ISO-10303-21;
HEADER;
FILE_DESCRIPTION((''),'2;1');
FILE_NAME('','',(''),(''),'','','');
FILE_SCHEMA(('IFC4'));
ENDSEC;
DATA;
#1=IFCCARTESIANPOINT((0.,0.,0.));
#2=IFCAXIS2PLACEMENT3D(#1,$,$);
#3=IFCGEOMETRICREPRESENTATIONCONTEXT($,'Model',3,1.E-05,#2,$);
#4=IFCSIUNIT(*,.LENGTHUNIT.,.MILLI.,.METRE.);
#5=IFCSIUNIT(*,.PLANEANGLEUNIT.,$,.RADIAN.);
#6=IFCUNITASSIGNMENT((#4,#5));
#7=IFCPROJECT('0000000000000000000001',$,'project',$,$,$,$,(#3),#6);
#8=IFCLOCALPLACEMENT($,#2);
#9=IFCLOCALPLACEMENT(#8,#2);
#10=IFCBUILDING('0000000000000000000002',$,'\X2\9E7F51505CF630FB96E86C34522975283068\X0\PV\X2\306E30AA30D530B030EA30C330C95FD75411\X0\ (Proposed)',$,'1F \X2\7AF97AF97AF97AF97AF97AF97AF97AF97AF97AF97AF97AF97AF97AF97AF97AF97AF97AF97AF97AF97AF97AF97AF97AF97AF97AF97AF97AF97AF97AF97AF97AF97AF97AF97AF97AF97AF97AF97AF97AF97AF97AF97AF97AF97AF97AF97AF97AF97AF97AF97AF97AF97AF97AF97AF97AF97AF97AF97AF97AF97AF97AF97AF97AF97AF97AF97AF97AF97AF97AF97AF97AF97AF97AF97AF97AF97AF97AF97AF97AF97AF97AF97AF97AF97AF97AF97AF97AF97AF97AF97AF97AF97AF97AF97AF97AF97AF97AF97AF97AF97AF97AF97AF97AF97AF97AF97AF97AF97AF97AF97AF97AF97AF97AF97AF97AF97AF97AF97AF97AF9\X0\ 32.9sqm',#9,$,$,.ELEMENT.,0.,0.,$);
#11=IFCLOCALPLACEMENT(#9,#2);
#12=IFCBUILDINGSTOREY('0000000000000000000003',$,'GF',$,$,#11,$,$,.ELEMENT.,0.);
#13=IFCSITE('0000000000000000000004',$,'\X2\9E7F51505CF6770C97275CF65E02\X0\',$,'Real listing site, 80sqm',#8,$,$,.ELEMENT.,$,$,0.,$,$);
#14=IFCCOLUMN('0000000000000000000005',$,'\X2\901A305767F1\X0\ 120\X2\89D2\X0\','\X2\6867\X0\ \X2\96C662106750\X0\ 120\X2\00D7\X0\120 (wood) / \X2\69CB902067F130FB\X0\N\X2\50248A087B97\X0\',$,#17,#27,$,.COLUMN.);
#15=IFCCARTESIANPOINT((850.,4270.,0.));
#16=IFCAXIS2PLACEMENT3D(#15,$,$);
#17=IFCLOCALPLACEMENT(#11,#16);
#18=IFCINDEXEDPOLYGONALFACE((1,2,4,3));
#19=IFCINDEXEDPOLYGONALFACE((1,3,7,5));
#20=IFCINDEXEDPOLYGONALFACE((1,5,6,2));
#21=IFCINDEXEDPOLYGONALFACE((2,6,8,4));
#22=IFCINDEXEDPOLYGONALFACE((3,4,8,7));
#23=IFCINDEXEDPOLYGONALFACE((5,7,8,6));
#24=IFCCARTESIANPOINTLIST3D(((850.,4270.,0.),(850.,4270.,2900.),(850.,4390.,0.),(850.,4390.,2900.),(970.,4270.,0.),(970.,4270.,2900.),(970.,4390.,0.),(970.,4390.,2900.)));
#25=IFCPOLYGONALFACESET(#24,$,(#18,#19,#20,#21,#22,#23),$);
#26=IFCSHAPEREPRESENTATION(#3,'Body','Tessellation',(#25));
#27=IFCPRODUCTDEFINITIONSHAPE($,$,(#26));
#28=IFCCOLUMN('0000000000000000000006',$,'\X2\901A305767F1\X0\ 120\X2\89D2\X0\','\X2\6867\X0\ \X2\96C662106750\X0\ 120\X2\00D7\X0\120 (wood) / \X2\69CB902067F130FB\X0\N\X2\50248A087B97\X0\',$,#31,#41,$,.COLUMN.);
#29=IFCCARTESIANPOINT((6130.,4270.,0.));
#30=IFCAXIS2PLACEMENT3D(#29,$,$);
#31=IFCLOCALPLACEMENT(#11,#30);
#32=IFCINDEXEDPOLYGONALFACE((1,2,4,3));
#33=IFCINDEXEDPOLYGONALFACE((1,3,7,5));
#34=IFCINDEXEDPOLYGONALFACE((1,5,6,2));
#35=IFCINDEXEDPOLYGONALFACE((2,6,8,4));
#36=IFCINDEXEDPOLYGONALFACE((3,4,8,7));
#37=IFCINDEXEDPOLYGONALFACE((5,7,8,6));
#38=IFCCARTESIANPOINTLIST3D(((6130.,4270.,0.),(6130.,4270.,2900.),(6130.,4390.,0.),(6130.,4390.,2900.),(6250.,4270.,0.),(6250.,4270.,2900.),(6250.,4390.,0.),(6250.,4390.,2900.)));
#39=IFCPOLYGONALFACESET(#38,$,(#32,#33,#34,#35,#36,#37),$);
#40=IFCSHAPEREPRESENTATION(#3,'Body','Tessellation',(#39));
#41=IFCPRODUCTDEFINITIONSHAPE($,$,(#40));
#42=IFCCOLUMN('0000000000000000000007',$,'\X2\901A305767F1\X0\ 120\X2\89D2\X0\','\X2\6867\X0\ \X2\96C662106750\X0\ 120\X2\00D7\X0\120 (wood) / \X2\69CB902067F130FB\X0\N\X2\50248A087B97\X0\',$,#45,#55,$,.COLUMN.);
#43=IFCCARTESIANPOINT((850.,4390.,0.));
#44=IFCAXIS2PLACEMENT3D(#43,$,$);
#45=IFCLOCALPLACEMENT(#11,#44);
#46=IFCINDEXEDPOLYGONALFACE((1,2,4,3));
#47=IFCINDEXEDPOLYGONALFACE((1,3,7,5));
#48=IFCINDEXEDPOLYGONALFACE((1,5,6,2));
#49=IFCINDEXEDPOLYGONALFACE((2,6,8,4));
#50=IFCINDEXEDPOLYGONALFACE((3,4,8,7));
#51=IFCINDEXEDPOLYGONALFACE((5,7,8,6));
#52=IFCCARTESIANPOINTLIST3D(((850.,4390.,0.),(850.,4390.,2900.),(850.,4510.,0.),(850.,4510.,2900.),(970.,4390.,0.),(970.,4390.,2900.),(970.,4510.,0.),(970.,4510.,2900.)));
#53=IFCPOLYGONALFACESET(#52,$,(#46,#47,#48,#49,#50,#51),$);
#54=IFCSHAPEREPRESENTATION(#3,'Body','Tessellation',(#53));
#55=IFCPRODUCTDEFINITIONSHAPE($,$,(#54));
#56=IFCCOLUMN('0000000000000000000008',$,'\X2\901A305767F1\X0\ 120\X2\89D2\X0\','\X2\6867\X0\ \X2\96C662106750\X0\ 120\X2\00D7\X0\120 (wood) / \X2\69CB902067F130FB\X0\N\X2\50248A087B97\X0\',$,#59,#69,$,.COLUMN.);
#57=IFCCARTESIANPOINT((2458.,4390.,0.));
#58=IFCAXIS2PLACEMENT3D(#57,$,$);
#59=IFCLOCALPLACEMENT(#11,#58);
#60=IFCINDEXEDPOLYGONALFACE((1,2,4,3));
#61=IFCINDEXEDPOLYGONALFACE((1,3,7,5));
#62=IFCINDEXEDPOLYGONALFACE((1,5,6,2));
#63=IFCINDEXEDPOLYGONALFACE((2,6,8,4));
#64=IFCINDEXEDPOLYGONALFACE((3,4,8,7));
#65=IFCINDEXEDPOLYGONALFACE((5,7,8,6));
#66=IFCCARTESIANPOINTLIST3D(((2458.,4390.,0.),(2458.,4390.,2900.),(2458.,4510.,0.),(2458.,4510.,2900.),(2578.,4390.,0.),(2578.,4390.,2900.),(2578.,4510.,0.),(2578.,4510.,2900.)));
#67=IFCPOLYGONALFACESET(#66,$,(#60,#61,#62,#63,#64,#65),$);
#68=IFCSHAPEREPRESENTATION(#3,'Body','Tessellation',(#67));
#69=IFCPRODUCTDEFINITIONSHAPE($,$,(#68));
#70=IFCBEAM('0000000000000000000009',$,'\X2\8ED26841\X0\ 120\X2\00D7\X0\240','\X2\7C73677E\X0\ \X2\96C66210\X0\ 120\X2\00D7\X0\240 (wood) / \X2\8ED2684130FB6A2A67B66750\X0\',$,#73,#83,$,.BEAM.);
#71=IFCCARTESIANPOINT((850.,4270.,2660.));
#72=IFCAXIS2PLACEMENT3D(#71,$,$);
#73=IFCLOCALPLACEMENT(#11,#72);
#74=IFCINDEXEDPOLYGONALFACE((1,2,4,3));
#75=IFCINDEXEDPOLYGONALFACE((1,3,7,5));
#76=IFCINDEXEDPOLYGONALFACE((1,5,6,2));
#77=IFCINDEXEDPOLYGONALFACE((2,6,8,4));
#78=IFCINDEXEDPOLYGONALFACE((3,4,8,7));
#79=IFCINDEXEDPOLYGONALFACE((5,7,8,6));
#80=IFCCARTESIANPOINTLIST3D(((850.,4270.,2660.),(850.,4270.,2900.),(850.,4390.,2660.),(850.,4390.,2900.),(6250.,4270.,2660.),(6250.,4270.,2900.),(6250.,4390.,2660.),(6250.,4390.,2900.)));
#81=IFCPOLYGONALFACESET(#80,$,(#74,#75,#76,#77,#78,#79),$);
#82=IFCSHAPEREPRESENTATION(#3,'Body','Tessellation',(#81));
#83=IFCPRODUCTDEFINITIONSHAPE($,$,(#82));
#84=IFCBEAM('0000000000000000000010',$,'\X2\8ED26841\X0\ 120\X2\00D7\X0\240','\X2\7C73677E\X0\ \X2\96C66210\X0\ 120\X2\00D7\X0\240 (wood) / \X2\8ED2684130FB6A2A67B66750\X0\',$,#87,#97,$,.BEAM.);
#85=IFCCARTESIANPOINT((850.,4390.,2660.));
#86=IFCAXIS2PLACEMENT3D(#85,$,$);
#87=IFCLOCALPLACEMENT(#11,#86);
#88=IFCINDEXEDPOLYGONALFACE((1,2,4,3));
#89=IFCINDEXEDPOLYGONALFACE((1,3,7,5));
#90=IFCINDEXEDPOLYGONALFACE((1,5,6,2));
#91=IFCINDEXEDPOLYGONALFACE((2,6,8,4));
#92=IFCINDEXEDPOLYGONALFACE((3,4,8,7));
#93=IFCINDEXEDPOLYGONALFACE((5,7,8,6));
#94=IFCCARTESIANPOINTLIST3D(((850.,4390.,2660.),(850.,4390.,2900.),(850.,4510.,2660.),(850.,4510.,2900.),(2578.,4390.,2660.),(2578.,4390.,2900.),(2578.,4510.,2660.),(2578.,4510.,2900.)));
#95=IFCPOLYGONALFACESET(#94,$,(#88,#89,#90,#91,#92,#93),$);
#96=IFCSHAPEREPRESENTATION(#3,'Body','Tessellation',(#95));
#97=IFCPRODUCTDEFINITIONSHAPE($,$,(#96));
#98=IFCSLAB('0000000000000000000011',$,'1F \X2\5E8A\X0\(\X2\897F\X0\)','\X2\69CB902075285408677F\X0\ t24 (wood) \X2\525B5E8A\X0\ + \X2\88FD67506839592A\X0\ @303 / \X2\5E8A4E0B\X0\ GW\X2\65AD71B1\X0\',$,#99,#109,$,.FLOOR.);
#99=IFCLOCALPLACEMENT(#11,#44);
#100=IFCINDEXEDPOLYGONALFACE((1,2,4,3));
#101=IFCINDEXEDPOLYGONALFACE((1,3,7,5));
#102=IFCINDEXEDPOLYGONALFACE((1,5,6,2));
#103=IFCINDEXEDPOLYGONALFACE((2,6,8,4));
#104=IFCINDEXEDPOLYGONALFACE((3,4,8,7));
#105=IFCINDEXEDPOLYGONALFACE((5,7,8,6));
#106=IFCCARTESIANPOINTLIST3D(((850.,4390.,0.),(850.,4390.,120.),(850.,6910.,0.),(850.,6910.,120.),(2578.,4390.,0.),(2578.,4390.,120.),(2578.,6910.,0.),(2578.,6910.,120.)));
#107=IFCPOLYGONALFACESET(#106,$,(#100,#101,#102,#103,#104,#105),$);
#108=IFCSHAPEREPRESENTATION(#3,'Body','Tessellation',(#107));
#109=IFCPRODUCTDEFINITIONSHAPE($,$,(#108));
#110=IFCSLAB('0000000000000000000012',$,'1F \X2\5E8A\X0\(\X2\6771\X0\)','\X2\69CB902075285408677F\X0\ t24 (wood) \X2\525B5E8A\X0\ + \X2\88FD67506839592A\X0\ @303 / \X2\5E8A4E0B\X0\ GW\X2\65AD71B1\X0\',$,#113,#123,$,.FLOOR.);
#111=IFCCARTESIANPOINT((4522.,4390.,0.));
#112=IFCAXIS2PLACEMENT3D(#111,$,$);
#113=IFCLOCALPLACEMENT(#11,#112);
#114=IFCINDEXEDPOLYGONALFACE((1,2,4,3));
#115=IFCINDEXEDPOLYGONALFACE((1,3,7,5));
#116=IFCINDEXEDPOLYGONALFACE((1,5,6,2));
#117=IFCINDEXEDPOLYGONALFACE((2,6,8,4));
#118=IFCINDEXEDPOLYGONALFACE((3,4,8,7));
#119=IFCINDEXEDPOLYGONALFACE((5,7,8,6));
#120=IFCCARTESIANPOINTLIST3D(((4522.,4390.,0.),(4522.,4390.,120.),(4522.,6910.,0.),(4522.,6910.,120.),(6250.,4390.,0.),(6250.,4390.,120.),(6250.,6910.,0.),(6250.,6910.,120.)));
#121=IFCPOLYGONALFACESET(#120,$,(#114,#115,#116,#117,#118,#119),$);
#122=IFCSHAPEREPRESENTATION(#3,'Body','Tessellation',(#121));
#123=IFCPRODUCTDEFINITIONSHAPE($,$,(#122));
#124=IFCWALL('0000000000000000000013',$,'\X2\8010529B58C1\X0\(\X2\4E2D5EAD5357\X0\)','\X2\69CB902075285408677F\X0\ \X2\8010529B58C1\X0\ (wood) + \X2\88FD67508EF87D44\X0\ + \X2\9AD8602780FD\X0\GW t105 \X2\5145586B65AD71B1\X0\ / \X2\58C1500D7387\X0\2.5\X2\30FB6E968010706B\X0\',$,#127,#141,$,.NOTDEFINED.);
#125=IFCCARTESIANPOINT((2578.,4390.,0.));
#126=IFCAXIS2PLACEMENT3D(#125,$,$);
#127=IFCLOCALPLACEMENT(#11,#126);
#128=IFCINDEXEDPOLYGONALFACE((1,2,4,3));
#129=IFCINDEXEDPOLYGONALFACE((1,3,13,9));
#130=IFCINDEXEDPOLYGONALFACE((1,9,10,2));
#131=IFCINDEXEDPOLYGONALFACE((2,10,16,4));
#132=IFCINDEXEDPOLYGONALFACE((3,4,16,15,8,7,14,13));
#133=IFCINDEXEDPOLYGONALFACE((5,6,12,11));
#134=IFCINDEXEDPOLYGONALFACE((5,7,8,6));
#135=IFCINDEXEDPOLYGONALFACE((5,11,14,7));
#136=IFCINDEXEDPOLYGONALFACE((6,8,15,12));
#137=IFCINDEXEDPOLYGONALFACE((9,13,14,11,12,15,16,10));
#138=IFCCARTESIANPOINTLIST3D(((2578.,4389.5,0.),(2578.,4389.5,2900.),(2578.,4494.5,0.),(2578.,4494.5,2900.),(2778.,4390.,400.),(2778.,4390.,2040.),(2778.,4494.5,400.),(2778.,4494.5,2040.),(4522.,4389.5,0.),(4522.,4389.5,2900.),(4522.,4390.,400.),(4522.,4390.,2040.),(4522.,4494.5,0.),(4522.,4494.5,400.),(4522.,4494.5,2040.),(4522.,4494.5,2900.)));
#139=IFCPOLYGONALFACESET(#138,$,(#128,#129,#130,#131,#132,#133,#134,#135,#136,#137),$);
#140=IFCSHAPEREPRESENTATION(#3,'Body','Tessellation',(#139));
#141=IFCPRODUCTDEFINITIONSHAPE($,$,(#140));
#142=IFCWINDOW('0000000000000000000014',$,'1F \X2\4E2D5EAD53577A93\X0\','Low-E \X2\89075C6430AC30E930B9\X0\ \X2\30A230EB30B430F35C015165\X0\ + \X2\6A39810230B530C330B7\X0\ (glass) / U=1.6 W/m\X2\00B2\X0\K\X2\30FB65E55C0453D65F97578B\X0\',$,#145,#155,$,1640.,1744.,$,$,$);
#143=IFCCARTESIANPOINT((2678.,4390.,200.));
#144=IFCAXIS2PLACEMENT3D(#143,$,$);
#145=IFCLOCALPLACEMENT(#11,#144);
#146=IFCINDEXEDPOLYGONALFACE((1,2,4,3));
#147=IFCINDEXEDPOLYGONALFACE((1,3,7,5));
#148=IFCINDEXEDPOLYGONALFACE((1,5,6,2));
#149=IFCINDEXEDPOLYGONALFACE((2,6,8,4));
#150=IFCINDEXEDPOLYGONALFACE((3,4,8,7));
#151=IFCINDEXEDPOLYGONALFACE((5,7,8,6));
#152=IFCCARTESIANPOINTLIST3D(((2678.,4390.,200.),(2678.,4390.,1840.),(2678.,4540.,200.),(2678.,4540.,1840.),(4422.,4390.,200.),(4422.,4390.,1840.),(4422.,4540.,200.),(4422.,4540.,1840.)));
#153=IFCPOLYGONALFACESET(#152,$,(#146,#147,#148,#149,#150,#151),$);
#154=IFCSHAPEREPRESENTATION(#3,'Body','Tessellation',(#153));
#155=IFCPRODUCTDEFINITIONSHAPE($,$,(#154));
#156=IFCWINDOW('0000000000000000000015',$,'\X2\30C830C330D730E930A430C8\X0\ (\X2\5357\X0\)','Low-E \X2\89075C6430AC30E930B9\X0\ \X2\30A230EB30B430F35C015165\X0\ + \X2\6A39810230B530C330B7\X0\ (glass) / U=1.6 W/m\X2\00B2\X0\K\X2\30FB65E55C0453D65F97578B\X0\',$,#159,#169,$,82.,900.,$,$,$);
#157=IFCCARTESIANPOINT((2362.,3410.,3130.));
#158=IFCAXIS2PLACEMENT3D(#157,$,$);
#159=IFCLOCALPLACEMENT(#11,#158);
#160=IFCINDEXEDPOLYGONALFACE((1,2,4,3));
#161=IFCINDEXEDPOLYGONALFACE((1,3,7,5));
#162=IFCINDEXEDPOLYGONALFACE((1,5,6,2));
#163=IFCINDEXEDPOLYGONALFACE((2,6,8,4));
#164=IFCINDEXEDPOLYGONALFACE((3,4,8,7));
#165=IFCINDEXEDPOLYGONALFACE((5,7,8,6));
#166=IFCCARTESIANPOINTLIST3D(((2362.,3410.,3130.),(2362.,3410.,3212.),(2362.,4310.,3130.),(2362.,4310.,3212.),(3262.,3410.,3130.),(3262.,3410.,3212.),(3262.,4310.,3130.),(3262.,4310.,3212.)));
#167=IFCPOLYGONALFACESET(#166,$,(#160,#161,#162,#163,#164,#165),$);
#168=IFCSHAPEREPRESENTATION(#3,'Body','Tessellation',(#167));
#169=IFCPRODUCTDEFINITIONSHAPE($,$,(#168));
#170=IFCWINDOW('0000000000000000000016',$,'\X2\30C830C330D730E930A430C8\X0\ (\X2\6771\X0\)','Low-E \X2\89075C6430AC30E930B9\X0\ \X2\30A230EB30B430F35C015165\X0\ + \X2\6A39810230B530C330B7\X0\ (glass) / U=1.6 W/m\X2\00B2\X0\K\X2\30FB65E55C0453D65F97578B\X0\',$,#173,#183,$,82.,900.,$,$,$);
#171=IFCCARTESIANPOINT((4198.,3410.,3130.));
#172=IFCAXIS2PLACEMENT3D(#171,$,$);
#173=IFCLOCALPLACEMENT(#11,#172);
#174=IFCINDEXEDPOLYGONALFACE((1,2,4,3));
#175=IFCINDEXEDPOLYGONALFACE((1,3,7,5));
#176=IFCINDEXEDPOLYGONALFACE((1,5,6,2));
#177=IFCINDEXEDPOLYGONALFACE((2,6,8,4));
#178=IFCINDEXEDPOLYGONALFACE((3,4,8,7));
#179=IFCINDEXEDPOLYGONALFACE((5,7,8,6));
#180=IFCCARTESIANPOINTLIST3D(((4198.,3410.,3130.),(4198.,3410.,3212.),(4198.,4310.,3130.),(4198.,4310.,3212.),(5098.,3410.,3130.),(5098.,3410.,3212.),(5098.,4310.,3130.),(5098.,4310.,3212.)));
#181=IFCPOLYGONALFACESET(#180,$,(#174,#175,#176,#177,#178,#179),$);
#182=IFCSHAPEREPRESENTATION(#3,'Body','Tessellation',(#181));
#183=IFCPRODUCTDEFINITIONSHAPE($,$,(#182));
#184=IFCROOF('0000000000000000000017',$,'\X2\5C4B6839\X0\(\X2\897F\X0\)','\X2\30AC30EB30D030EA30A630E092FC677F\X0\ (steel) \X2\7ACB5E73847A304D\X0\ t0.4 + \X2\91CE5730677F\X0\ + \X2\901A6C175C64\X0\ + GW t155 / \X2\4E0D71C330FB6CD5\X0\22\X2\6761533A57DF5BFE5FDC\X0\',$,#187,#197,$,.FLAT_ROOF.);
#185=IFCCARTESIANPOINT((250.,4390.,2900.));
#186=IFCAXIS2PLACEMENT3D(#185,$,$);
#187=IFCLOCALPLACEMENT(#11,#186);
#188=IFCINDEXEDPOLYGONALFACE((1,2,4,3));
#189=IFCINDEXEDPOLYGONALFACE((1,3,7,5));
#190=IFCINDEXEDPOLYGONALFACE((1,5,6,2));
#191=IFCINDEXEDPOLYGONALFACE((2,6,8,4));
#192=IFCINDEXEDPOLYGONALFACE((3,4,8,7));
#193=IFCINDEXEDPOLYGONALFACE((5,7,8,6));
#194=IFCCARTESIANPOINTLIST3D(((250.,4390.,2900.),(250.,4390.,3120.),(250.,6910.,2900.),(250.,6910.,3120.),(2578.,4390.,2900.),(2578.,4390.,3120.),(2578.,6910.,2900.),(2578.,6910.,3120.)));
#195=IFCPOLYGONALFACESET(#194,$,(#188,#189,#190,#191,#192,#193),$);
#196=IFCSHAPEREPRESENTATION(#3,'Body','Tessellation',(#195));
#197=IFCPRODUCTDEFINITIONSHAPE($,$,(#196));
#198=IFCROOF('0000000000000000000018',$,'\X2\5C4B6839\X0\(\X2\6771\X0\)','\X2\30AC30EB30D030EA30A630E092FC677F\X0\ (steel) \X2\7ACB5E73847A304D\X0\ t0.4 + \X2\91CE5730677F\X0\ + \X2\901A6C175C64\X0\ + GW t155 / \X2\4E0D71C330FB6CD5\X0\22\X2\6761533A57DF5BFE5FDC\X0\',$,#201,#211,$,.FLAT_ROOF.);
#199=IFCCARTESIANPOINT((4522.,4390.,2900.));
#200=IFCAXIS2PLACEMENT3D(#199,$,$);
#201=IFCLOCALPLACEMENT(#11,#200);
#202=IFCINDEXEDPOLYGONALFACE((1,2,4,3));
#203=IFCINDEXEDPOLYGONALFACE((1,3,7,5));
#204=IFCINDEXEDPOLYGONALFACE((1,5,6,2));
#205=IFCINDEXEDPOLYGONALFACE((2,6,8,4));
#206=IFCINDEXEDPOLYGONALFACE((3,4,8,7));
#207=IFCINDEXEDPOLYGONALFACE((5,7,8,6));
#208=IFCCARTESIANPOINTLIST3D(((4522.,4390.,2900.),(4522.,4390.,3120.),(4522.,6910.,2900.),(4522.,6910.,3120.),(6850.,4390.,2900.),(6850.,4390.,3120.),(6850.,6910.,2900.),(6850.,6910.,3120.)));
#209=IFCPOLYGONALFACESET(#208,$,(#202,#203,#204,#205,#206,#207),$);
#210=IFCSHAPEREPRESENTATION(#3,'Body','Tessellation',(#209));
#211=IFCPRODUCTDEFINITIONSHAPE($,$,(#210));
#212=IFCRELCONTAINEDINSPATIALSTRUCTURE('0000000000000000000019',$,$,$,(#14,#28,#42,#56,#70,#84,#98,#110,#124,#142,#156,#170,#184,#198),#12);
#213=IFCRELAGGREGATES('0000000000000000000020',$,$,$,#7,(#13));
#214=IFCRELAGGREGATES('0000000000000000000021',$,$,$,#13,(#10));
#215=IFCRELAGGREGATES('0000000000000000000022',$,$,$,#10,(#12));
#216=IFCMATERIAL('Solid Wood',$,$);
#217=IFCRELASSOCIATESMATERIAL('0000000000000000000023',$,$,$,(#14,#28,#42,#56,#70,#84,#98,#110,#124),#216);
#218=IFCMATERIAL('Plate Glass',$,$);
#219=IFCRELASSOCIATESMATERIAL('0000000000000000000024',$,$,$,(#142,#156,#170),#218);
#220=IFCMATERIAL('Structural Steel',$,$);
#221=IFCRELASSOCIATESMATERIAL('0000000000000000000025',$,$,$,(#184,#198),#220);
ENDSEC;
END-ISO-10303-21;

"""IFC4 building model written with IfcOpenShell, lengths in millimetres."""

from ifc_helpers import new_model, si_unit, frame, frame_2d, origin, place, context, project, spatial, rectangle, extrude, material, element, fill, save


model = new_model("IFC4")

# Units and contexts
model_context = context("Model", 3, precision=1e-05, world=origin())
ifc_project = project(units=[si_unit("LENGTHUNIT", "METRE", prefix="MILLI"), si_unit("PLANEANGLEUNIT", "RADIAN")], contexts=[model_context])

# Site, building, storey
site_placement = place(None, origin())
site = spatial("IfcSite", under=ifc_project, at=site_placement, Name="鹿児島県霧島市", ObjectType="Real listing site, 80sqm", CompositionType="ELEMENT", RefElevation=0.0)
building_placement = place(site_placement, origin())
building = spatial("IfcBuilding", under=site, at=building_placement, Name="鹿児島・雨水利用とPVのオフグリッド志向 (Proposed)", ObjectType="1F 竹竹竹竹竹竹竹竹竹竹竹竹竹竹竹竹竹竹竹竹竹竹竹竹竹竹竹竹竹竹竹竹竹竹竹竹竹竹竹竹竹竹竹竹竹竹竹竹竹竹竹竹竹竹竹竹竹竹竹竹竹竹竹竹竹竹竹竹竹竹竹竹竹竹竹竹竹竹竹竹竹竹竹竹竹竹竹竹竹竹竹竹竹竹竹竹竹竹竹竹竹竹竹竹竹竹竹竹竹竹竹竹竹竹竹竹竹竹竹竹 32.9sqm", CompositionType="ELEMENT", ElevationOfRefHeight=0.0, ElevationOfTerrain=0.0)
storey_placement = place(building_placement, origin())
storey = spatial("IfcBuildingStorey", under=building, at=storey_placement, Name="GF", CompositionType="ELEMENT", Elevation=0.0)

# Columns
ifc_material_1 = material(Name="Solid Wood")
column_1_placement = place(storey_placement, frame((850.0, 4270.0, 0.0)))
element("IfcColumn", 1, at=column_1_placement, inside=storey, material=ifc_material_1, Name="通し柱 120角", Description="桧 集成材 120×120 (wood) / 構造柱・N値計算", PredefinedType="COLUMN", context=model_context, shape_type="SweptSolid", body=[
    extrude(rectangle(XDim=120.0, YDim=120.0, at=frame_2d((60.0, 60.0))), frame((850.0, 4270.0, 0.0)), (0.0, 0.0, 1.0), 2900.0),
])
column_2_placement = place(storey_placement, frame((6130.0, 4270.0, 0.0)))
element("IfcColumn", 2, at=column_2_placement, inside=storey, material=ifc_material_1, Name="通し柱 120角", Description="桧 集成材 120×120 (wood) / 構造柱・N値計算", PredefinedType="COLUMN", context=model_context, shape_type="SweptSolid", body=[
    extrude(rectangle(XDim=120.0, YDim=120.0, at=frame_2d((60.0, 60.0))), frame((6130.0, 4270.0, 0.0)), (0.0, 0.0, 1.0), 2900.0),
])
column_3_placement = place(storey_placement, frame((850.0, 4390.0, 0.0)))
element("IfcColumn", 3, at=column_3_placement, inside=storey, material=ifc_material_1, Name="通し柱 120角", Description="桧 集成材 120×120 (wood) / 構造柱・N値計算", PredefinedType="COLUMN", context=model_context, shape_type="SweptSolid", body=[
    extrude(rectangle(XDim=120.0, YDim=120.0, at=frame_2d((60.0, 60.0))), frame((850.0, 4390.0, 0.0)), (0.0, 0.0, 1.0), 2900.0),
])
column_4_placement = place(storey_placement, frame((2458.0, 4390.0, 0.0)))
element("IfcColumn", 4, at=column_4_placement, inside=storey, material=ifc_material_1, Name="通し柱 120角", Description="桧 集成材 120×120 (wood) / 構造柱・N値計算", PredefinedType="COLUMN", context=model_context, shape_type="SweptSolid", body=[
    extrude(rectangle(XDim=120.0, YDim=120.0, at=frame_2d((60.0, 60.0))), frame((2458.0, 4390.0, 0.0)), (0.0, 0.0, 1.0), 2900.0),
])

# Beams
beam_1_placement = place(storey_placement, frame((850.0, 4270.0, 2660.0)))
element("IfcBeam", 5, at=beam_1_placement, inside=storey, material=ifc_material_1, Name="軒桁 120×240", Description="米松 集成 120×240 (wood) / 軒桁・横架材", PredefinedType="BEAM", context=model_context, shape_type="SweptSolid", body=[
    extrude(rectangle(XDim=5400.0, YDim=120.0, at=frame_2d((2700.0, 60.0))), frame((850.0, 4270.0, 2660.0)), (0.0, 0.0, 1.0), 240.0),
])
beam_2_placement = place(storey_placement, frame((850.0, 4390.0, 2660.0)))
element("IfcBeam", 6, at=beam_2_placement, inside=storey, material=ifc_material_1, Name="軒桁 120×240", Description="米松 集成 120×240 (wood) / 軒桁・横架材", PredefinedType="BEAM", context=model_context, shape_type="SweptSolid", body=[
    extrude(rectangle(XDim=1728.0, YDim=120.0, at=frame_2d((864.0, 60.0))), frame((850.0, 4390.0, 2660.0)), (0.0, 0.0, 1.0), 240.0),
])

# Slabs
slab_1_placement = place(storey_placement, frame((850.0, 4390.0, 0.0)))
element("IfcSlab", 7, at=slab_1_placement, inside=storey, material=ifc_material_1, Name="1F 床(西)", Description="構造用合板 t24 (wood) 剛床 + 製材根太 @303 / 床下 GW断熱", PredefinedType="FLOOR", context=model_context, shape_type="SweptSolid", body=[
    extrude(rectangle(XDim=1728.0, YDim=2520.0, at=frame_2d((864.0, 1260.0))), frame((850.0, 4390.0, 0.0)), (0.0, 0.0, 1.0), 120.0),
])
slab_2_placement = place(storey_placement, frame((4522.0, 4390.0, 0.0)))
element("IfcSlab", 8, at=slab_2_placement, inside=storey, material=ifc_material_1, Name="1F 床(東)", Description="構造用合板 t24 (wood) 剛床 + 製材根太 @303 / 床下 GW断熱", PredefinedType="FLOOR", context=model_context, shape_type="SweptSolid", body=[
    extrude(rectangle(XDim=1728.0, YDim=2520.0, at=frame_2d((864.0, 1260.0))), frame((4522.0, 4390.0, 0.0)), (0.0, 0.0, 1.0), 120.0),
])

# Wall, opening, window
wall_1_placement = place(storey_placement, frame((2578.0, 4390.0, 0.0)))
wall_1 = element("IfcWall", 9, at=wall_1_placement, inside=storey, material=ifc_material_1, Name="耐力壁(中庭南)", Description="構造用合板 耐力壁 (wood) + 製材軸組 + 高性能GW t105 充填断熱 / 壁倍率2.5・準耐火", PredefinedType="NOTDEFINED", context=model_context, shape_type="SweptSolid", body=[
    extrude(rectangle(XDim=1944.0, YDim=105.0, at=frame_2d((972.0, 52.0))), frame((2578.0, 4390.0, 0.0)), (0.0, 0.0, 1.0), 2900.0),
])
opening_placement = place(storey_placement, frame((2678.0, 4390.0, 200.0)))
opening = element("IfcOpeningElement", 10, at=opening_placement, cuts=wall_1, PredefinedType="NOTDEFINED", context=model_context, shape_type="SweptSolid", body=[
    extrude(rectangle(XDim=1744.0, YDim=150.0, at=frame_2d((872.0, 75.0))), frame((2678.0, 4390.0, 200.0)), (0.0, 0.0, 1.0), 1640.0),
])
ifc_material_2 = material(Name="Plate Glass")
window_1_placement = place(storey_placement, frame((2678.0, 4390.0, 200.0)))
window_1 = element("IfcWindow", 11, at=window_1_placement, inside=storey, material=ifc_material_2, Name="1F 中庭南窓", Description="Low-E 複層ガラス アルゴン封入 + 樹脂サッシ (glass) / U=1.6 W/m²K・日射取得型", OverallHeight=1640.0, OverallWidth=1744.0, context=model_context, shape_type="SweptSolid", body=[
    extrude(rectangle(XDim=1744.0, YDim=150.0, at=frame_2d((872.0, 75.0))), frame((2678.0, 4390.0, 200.0)), (0.0, 0.0, 1.0), 1640.0),
])
fill(opening, window_1)

# Windows
window_2_placement = place(storey_placement, frame((2362.0, 3410.0, 3130.0)))
element("IfcWindow", 12, at=window_2_placement, inside=storey, material=ifc_material_2, Name="トップライト (南)", Description="Low-E 複層ガラス アルゴン封入 + 樹脂サッシ (glass) / U=1.6 W/m²K・日射取得型", OverallHeight=82.0, OverallWidth=900.0, context=model_context, shape_type="SweptSolid", body=[
    extrude(rectangle(XDim=900.0, YDim=900.0, at=frame_2d((450.0, 450.0))), frame((2362.0, 3410.0, 3130.0)), (0.0, 0.0, 1.0), 82.0),
])
window_3_placement = place(storey_placement, frame((4198.0, 3410.0, 3130.0)))
element("IfcWindow", 13, at=window_3_placement, inside=storey, material=ifc_material_2, Name="トップライト (東)", Description="Low-E 複層ガラス アルゴン封入 + 樹脂サッシ (glass) / U=1.6 W/m²K・日射取得型", OverallHeight=82.0, OverallWidth=900.0, context=model_context, shape_type="SweptSolid", body=[
    extrude(rectangle(XDim=900.0, YDim=900.0, at=frame_2d((450.0, 450.0))), frame((4198.0, 3410.0, 3130.0)), (0.0, 0.0, 1.0), 82.0),
])

# Roofs
ifc_material_3 = material(Name="Structural Steel")
roof_1_placement = place(storey_placement, frame((250.0, 4390.0, 2900.0)))
element("IfcRoof", 14, at=roof_1_placement, inside=storey, material=ifc_material_3, Name="屋根(西)", Description="ガルバリウム鋼板 (steel) 立平葺き t0.4 + 野地板 + 通気層 + GW t155 / 不燃・法22条区域対応", PredefinedType="FLAT_ROOF", context=model_context, shape_type="SweptSolid", body=[
    extrude(rectangle(XDim=2328.0, YDim=2520.0, at=frame_2d((1164.0, 1260.0))), frame((250.0, 4390.0, 2900.0)), (0.0, 0.0, 1.0), 220.0),
])
roof_2_placement = place(storey_placement, frame((4522.0, 4390.0, 2900.0)))
element("IfcRoof", 15, at=roof_2_placement, inside=storey, material=ifc_material_3, Name="屋根(東)", Description="ガルバリウム鋼板 (steel) 立平葺き t0.4 + 野地板 + 通気層 + GW t155 / 不燃・法22条区域対応", PredefinedType="FLAT_ROOF", context=model_context, shape_type="SweptSolid", body=[
    extrude(rectangle(XDim=2328.0, YDim=2520.0, at=frame_2d((1164.0, 1260.0))), frame((4522.0, 4390.0, 2900.0)), (0.0, 0.0, 1.0), 220.0),
])

save(model, "model.ifc")
